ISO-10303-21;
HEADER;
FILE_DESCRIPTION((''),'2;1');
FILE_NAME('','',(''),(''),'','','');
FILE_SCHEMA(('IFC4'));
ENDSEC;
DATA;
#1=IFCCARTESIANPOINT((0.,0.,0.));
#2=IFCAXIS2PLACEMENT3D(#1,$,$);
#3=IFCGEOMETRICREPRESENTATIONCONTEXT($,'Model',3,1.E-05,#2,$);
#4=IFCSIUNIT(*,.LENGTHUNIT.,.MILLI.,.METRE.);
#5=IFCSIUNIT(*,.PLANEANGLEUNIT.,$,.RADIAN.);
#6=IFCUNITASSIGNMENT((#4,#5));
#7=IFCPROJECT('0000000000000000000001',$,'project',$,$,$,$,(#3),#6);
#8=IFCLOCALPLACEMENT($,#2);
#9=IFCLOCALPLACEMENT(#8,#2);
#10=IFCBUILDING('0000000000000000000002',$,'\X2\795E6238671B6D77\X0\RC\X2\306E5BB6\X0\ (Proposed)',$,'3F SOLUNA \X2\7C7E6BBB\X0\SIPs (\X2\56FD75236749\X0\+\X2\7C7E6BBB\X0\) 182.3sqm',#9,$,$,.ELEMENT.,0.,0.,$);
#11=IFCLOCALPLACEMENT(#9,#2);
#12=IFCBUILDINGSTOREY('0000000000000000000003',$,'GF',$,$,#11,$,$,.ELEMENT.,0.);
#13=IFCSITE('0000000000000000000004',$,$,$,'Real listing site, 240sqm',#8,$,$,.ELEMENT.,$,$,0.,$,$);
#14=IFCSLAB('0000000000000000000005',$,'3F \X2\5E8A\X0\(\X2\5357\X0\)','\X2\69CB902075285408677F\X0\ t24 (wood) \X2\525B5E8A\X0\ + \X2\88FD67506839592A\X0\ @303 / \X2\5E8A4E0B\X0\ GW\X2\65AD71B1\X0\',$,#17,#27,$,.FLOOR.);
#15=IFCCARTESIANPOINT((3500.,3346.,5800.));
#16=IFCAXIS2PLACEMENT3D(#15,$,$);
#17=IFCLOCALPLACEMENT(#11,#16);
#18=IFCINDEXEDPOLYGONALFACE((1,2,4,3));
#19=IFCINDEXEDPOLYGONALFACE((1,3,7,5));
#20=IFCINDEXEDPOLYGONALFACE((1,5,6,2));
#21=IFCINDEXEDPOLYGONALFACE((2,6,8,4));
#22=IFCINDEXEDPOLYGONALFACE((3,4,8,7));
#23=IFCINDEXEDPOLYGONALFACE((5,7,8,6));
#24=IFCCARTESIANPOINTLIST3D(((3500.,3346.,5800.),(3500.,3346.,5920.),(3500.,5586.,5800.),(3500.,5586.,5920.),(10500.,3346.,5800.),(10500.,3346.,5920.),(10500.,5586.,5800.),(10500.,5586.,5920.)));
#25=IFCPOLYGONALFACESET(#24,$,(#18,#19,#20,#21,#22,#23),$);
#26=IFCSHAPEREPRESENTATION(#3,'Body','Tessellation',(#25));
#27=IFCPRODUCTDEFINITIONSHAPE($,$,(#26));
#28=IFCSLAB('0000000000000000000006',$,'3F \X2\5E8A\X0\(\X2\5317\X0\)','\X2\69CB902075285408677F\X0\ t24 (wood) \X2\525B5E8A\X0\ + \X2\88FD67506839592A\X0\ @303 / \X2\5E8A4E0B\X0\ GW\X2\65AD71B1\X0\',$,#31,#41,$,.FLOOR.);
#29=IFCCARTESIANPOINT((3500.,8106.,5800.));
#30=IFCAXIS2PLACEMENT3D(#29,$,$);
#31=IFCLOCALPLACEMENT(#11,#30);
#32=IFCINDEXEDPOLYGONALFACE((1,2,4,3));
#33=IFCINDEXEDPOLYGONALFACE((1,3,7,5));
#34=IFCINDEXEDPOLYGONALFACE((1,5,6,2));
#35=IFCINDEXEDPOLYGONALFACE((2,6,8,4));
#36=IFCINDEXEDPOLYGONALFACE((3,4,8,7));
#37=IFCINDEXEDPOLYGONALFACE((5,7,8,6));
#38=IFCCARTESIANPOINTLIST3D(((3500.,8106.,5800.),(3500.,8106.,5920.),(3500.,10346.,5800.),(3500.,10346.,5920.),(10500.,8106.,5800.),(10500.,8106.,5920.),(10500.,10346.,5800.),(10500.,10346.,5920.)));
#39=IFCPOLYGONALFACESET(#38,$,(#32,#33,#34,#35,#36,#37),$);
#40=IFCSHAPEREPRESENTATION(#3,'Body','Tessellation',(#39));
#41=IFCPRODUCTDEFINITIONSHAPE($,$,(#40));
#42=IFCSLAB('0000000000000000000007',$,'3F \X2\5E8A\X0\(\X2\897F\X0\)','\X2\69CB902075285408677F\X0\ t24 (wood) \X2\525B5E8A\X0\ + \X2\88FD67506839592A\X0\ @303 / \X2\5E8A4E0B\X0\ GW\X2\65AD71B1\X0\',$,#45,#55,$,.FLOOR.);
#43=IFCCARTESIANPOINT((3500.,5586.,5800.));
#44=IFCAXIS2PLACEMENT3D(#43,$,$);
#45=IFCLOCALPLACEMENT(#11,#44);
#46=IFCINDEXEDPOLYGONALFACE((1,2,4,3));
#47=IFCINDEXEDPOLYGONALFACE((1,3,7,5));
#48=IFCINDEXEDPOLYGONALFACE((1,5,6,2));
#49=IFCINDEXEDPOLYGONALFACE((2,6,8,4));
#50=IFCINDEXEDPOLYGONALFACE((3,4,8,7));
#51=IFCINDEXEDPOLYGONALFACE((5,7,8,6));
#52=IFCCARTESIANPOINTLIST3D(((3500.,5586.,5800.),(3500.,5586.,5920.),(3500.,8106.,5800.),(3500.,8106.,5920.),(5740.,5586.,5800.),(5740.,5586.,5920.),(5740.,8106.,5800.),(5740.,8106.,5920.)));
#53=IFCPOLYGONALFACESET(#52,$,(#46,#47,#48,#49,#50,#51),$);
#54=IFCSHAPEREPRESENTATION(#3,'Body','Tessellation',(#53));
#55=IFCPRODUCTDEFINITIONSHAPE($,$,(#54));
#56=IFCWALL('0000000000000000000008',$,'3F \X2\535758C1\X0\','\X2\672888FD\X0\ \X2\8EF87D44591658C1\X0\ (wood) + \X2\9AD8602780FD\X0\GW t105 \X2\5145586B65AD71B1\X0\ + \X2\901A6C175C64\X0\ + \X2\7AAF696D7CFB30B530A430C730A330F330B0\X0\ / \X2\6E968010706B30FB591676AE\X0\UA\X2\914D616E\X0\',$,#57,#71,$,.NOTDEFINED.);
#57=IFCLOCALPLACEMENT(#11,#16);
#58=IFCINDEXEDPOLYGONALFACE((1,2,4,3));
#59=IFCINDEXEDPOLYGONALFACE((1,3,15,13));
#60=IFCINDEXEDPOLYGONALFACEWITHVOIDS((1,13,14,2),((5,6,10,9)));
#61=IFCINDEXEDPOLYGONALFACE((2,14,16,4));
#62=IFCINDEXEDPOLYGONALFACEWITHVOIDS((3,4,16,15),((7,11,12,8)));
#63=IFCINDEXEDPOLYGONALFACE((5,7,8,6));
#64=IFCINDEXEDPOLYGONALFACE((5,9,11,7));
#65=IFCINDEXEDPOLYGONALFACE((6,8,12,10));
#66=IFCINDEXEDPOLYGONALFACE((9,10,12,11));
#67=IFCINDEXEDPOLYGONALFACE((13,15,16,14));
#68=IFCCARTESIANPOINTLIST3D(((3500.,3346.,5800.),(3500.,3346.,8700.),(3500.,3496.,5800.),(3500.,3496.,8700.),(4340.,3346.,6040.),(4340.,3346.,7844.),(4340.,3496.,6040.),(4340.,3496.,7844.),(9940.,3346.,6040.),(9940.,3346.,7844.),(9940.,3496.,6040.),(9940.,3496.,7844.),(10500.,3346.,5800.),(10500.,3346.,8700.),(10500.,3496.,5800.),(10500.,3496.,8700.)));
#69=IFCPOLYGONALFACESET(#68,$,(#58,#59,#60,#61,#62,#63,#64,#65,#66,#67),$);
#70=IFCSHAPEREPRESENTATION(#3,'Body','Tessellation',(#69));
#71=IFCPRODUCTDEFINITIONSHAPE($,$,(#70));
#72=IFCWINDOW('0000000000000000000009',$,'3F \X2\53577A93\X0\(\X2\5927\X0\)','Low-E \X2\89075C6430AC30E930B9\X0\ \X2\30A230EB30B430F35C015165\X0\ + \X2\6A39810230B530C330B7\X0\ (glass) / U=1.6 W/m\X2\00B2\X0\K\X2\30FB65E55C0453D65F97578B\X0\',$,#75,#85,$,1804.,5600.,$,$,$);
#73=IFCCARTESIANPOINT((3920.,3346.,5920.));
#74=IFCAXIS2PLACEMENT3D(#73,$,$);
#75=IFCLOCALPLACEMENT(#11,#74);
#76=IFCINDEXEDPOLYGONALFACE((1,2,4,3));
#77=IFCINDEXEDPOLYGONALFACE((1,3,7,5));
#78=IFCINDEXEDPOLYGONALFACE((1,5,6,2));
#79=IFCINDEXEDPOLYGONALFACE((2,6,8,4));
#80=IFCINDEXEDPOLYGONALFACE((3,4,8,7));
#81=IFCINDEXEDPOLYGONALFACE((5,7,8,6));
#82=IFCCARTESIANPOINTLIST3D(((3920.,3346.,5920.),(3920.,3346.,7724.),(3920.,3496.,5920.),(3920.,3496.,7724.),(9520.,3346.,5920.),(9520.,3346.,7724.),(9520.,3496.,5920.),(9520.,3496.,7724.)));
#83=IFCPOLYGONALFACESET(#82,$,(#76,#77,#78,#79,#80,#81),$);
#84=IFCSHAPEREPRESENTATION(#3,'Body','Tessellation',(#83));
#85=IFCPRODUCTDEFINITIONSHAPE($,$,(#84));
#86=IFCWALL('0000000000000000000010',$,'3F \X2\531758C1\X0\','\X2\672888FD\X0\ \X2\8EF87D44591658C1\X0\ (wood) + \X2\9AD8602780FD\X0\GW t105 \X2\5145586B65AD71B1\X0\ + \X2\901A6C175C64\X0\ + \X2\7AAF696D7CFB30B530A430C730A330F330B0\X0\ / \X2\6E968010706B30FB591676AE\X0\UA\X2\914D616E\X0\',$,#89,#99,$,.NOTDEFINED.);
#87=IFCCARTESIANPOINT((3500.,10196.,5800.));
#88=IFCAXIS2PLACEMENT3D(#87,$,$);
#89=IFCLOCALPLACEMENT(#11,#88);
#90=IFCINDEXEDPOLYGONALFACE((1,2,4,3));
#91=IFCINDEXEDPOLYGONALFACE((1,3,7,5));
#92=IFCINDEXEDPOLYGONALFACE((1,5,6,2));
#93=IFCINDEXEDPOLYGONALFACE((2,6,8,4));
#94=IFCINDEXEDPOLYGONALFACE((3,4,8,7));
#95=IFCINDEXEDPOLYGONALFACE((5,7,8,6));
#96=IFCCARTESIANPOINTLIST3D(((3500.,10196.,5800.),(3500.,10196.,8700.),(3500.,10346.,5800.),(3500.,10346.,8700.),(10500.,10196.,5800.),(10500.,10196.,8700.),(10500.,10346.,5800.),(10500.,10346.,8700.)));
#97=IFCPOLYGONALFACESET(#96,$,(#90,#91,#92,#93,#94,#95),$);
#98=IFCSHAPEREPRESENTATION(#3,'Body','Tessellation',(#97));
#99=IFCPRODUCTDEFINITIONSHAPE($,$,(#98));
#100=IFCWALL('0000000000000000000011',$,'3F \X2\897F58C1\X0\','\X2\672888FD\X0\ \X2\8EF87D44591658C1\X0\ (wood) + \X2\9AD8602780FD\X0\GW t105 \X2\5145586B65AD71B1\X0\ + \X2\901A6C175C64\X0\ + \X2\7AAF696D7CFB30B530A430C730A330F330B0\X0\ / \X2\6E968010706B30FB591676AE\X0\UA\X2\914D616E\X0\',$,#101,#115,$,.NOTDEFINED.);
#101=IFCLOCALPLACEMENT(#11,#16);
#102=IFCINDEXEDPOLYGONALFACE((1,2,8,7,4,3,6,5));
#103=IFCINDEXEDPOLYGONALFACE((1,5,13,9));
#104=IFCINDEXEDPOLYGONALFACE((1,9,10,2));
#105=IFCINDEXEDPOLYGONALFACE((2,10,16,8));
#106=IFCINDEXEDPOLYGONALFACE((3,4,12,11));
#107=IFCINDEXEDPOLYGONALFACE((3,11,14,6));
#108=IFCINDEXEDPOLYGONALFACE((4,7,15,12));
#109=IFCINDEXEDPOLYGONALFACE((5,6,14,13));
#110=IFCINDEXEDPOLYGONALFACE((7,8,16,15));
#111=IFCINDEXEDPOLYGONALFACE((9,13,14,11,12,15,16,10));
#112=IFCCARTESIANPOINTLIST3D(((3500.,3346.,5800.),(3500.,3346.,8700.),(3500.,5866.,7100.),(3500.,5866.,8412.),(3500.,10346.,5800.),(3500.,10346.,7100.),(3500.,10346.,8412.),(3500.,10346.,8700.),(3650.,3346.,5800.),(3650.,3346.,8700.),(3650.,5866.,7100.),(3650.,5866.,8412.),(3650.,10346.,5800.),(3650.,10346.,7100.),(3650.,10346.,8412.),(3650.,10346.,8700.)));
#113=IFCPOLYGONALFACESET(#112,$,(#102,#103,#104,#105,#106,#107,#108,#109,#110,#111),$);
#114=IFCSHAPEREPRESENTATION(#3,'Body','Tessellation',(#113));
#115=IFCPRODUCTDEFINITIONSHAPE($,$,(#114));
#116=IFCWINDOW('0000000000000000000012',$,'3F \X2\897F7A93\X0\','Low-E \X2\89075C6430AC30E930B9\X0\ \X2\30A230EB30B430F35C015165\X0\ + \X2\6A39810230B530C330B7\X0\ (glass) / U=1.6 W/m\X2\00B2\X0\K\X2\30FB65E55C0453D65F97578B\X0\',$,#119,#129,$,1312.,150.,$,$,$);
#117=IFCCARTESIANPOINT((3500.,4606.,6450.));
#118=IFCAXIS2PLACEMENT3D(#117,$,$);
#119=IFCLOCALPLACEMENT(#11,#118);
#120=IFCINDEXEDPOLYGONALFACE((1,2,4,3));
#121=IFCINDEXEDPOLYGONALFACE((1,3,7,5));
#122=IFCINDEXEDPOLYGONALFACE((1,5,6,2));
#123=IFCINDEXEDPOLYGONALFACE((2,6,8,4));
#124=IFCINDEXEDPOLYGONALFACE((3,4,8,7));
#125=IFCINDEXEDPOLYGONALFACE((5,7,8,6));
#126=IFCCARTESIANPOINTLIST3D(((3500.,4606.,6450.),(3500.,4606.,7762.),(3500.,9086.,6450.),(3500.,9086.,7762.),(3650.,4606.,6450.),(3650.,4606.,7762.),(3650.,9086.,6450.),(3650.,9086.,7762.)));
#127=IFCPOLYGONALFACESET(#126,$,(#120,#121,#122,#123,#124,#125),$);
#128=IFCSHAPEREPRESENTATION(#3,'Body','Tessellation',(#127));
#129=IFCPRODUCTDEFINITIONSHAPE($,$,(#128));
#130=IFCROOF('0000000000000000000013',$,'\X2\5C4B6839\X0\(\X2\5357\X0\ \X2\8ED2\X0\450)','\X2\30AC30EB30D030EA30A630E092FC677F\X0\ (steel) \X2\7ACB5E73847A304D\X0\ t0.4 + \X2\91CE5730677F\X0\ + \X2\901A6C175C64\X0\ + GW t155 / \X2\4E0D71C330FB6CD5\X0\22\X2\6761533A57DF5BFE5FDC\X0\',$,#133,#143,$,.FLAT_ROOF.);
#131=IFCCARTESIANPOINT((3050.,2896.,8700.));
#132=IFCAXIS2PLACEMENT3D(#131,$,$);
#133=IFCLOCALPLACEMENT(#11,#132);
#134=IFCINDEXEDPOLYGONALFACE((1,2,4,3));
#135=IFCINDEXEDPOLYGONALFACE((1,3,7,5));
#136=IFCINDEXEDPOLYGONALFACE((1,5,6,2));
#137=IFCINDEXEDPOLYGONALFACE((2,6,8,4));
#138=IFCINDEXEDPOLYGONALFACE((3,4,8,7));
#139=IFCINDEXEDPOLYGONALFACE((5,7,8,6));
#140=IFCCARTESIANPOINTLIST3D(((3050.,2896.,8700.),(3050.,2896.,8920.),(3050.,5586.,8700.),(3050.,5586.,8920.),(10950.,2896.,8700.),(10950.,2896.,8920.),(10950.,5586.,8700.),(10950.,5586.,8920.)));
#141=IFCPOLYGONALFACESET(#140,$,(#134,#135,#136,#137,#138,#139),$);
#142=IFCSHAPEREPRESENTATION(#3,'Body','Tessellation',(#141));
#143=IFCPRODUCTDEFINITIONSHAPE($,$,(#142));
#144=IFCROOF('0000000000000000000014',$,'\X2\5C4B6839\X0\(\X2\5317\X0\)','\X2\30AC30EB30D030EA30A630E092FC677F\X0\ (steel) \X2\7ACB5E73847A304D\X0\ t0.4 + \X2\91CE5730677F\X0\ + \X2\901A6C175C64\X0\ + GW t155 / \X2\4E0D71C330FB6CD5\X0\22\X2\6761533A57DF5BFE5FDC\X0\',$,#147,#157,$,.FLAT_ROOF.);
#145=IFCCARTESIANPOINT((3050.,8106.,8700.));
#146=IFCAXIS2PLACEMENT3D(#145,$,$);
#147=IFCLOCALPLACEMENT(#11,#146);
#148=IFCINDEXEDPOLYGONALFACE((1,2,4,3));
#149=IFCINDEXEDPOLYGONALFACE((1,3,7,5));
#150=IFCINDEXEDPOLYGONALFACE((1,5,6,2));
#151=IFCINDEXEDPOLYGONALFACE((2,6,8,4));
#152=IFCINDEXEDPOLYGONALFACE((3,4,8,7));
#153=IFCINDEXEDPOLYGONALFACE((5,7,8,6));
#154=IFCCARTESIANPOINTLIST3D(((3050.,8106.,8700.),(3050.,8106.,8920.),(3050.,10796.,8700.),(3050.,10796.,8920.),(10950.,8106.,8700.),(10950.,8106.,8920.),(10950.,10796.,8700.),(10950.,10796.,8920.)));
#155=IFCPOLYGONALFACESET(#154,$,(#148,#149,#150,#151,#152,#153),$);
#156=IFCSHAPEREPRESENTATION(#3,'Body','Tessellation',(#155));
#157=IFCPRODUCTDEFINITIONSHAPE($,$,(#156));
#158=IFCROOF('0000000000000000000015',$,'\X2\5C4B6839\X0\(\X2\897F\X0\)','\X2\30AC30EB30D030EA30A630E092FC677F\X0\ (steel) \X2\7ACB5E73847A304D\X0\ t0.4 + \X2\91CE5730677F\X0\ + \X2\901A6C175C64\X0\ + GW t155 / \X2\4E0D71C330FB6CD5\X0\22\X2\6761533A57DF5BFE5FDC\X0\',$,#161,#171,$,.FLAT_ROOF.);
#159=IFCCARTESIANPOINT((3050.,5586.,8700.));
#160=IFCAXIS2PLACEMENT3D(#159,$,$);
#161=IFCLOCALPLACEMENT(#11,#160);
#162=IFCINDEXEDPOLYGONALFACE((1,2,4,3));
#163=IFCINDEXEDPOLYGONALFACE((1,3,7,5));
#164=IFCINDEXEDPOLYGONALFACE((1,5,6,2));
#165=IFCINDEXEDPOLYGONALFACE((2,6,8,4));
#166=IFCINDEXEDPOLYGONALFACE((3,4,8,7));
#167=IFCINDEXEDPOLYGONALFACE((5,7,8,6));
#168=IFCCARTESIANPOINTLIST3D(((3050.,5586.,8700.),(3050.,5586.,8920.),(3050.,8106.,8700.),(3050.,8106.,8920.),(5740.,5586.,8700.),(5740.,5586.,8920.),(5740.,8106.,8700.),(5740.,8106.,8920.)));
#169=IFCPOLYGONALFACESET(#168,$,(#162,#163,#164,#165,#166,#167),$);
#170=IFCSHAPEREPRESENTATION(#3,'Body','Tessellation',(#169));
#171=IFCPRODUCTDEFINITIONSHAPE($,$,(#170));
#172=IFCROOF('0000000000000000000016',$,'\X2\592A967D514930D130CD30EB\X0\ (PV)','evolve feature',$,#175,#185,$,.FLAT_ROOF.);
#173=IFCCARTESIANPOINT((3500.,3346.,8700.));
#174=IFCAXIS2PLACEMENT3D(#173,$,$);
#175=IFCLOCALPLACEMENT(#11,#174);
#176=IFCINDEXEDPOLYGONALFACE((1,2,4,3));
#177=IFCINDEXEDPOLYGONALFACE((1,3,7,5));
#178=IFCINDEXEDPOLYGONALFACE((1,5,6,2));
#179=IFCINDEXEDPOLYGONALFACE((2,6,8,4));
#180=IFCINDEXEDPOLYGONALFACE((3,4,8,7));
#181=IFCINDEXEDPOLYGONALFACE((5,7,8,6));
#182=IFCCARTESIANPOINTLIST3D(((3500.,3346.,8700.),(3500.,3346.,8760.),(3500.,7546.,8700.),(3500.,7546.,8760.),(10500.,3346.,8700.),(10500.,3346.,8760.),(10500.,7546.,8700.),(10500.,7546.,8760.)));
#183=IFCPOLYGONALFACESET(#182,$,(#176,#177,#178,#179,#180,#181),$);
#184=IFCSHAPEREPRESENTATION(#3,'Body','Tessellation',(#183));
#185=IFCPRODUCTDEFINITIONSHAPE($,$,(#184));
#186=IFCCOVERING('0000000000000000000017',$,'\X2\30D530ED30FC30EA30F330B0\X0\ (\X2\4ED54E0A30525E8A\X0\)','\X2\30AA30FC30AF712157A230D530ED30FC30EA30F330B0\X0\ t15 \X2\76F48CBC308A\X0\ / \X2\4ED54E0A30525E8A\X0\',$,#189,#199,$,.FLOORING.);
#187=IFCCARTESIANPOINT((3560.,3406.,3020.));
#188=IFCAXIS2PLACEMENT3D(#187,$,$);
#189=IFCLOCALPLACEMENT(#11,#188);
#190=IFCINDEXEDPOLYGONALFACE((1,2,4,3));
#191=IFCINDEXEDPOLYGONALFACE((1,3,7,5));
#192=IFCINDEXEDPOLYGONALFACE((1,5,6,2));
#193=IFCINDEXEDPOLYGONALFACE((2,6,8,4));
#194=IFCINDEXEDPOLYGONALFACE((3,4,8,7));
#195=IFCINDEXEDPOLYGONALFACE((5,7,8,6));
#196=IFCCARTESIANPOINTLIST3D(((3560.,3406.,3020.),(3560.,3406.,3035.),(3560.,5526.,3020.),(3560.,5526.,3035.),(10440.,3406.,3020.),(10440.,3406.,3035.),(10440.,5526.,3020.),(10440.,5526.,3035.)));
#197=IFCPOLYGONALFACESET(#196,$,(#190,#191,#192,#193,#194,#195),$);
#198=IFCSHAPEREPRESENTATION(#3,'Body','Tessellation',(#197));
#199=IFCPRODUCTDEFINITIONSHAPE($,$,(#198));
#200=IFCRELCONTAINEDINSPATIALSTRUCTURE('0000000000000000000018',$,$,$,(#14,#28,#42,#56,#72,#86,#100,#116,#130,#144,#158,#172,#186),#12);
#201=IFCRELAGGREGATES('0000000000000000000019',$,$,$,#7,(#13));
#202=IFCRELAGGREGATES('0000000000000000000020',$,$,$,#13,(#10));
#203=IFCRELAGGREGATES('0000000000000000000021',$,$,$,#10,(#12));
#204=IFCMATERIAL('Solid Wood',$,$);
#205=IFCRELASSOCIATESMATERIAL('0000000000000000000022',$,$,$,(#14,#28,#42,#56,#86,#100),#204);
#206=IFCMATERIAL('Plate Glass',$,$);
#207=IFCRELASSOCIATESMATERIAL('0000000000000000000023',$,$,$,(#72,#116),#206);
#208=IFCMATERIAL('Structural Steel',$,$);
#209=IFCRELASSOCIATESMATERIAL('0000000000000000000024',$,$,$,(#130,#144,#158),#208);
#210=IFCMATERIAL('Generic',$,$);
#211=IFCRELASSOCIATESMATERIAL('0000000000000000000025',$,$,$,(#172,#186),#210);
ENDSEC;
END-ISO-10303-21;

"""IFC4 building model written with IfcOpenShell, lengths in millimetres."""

from ifc_helpers import new_model, si_unit, frame, frame_2d, origin, place, context, project, spatial, rectangle, extrude, material, element, fill, save


model = new_model("IFC4")

# Units and contexts
model_context = context("Model", 3, precision=1e-05, world=origin())
ifc_project = project(units=[si_unit("LENGTHUNIT", "METRE", prefix="MILLI"), si_unit("PLANEANGLEUNIT", "RADIAN")], contexts=[model_context])

# Site, building, storey
site_placement = place(None, origin())
site = spatial("IfcSite", under=ifc_project, at=site_placement, ObjectType="Real listing site, 240sqm", CompositionType="ELEMENT", RefElevation=0.0)
building_placement = place(site_placement, origin())
building = spatial("IfcBuilding", under=site, at=building_placement, Name="神戸望海RCの家 (Proposed)", ObjectType="3F SOLUNA 籾殻SIPs (国産杉+籾殻) 182.3sqm", CompositionType="ELEMENT", ElevationOfRefHeight=0.0, ElevationOfTerrain=0.0)
storey_placement = place(building_placement, origin())
storey = spatial("IfcBuildingStorey", under=building, at=storey_placement, Name="GF", CompositionType="ELEMENT", Elevation=0.0)

# Slabs
ifc_material_1 = material(Name="Solid Wood")
slab_1_placement = place(storey_placement, frame((3500.0, 3346.0, 5800.0)))
element("IfcSlab", 1, at=slab_1_placement, inside=storey, material=ifc_material_1, Name="3F 床(南)", Description="構造用合板 t24 (wood) 剛床 + 製材根太 @303 / 床下 GW断熱", PredefinedType="FLOOR", context=model_context, shape_type="SweptSolid", body=[
    extrude(rectangle(XDim=7000.0, YDim=2240.0, at=frame_2d((3500.0, 1120.0))), frame((3500.0, 3346.0, 5800.0)), (0.0, 0.0, 1.0), 120.0),
])
slab_2_placement = place(storey_placement, frame((3500.0, 8106.0, 5800.0)))
element("IfcSlab", 2, at=slab_2_placement, inside=storey, material=ifc_material_1, Name="3F 床(北)", Description="構造用合板 t24 (wood) 剛床 + 製材根太 @303 / 床下 GW断熱", PredefinedType="FLOOR", context=model_context, shape_type="SweptSolid", body=[
    extrude(rectangle(XDim=7000.0, YDim=2240.0, at=frame_2d((3500.0, 1120.0))), frame((3500.0, 8106.0, 5800.0)), (0.0, 0.0, 1.0), 120.0),
])
slab_3_placement = place(storey_placement, frame((3500.0, 5586.0, 5800.0)))
element("IfcSlab", 3, at=slab_3_placement, inside=storey, material=ifc_material_1, Name="3F 床(西)", Description="構造用合板 t24 (wood) 剛床 + 製材根太 @303 / 床下 GW断熱", PredefinedType="FLOOR", context=model_context, shape_type="SweptSolid", body=[
    extrude(rectangle(XDim=2240.0, YDim=2520.0, at=frame_2d((1120.0, 1260.0))), frame((3500.0, 5586.0, 5800.0)), (0.0, 0.0, 1.0), 120.0),
])

# Wall, opening, window
wall_1_placement = place(storey_placement, frame((3500.0, 3346.0, 5800.0)))
wall_1 = element("IfcWall", 4, at=wall_1_placement, inside=storey, material=ifc_material_1, Name="3F 南壁", Description="木製 軸組外壁 (wood) + 高性能GW t105 充填断熱 + 通気層 + 窯業系サイディング / 準耐火・外皮UA配慮", PredefinedType="NOTDEFINED", context=model_context, shape_type="SweptSolid", body=[
    extrude(rectangle(XDim=7000.0, YDim=150.0, at=frame_2d((3500.0, 75.0))), frame((3500.0, 3346.0, 5800.0)), (0.0, 0.0, 1.0), 2900.0),
])
opening_1_placement = place(storey_placement, frame((3920.0, 3346.0, 5920.0)))
opening_1 = element("IfcOpeningElement", 5, at=opening_1_placement, cuts=wall_1, PredefinedType="NOTDEFINED", context=model_context, shape_type="SweptSolid", body=[
    extrude(rectangle(XDim=5600.0, YDim=150.0, at=frame_2d((2800.0, 75.0))), frame((3920.0, 3346.0, 5920.0)), (0.0, 0.0, 1.0), 1804.0),
])
ifc_material_2 = material(Name="Plate Glass")
window_1_placement = place(storey_placement, frame((3920.0, 3346.0, 5920.0)))
window_1 = element("IfcWindow", 6, at=window_1_placement, inside=storey, material=ifc_material_2, Name="3F 南窓(大)", Description="Low-E 複層ガラス アルゴン封入 + 樹脂サッシ (glass) / U=1.6 W/m²K・日射取得型", OverallHeight=1804.0, OverallWidth=5600.0, context=model_context, shape_type="SweptSolid", body=[
    extrude(rectangle(XDim=5600.0, YDim=150.0, at=frame_2d((2800.0, 75.0))), frame((3920.0, 3346.0, 5920.0)), (0.0, 0.0, 1.0), 1804.0),
])
fill(opening_1, window_1)

# Wall
wall_2_placement = place(storey_placement, frame((3500.0, 10196.0, 5800.0)))
element("IfcWall", 7, at=wall_2_placement, inside=storey, material=ifc_material_1, Name="3F 北壁", Description="木製 軸組外壁 (wood) + 高性能GW t105 充填断熱 + 通気層 + 窯業系サイディング / 準耐火・外皮UA配慮", PredefinedType="NOTDEFINED", context=model_context, shape_type="SweptSolid", body=[
    extrude(rectangle(XDim=7000.0, YDim=150.0, at=frame_2d((3500.0, 75.0))), frame((3500.0, 10196.0, 5800.0)), (0.0, 0.0, 1.0), 2900.0),
])

# Wall, opening, window
wall_3_placement = place(storey_placement, frame((3500.0, 3346.0, 5800.0)))
wall_3 = element("IfcWall", 8, at=wall_3_placement, inside=storey, material=ifc_material_1, Name="3F 西壁", Description="木製 軸組外壁 (wood) + 高性能GW t105 充填断熱 + 通気層 + 窯業系サイディング / 準耐火・外皮UA配慮", PredefinedType="NOTDEFINED", context=model_context, shape_type="SweptSolid", body=[
    extrude(rectangle(XDim=150.0, YDim=7000.0, at=frame_2d((75.0, 3500.0))), frame((3500.0, 3346.0, 5800.0)), (0.0, 0.0, 1.0), 2900.0),
])
opening_2_placement = place(storey_placement, frame((3500.0, 4606.0, 6450.0)))
opening_2 = element("IfcOpeningElement", 9, at=opening_2_placement, cuts=wall_3, PredefinedType="NOTDEFINED", context=model_context, shape_type="SweptSolid", body=[
    extrude(rectangle(XDim=150.0, YDim=4480.0, at=frame_2d((75.0, 2240.0))), frame((3500.0, 4606.0, 6450.0)), (0.0, 0.0, 1.0), 1312.0),
])
window_2_placement = place(storey_placement, frame((3500.0, 4606.0, 6450.0)))
window_2 = element("IfcWindow", 10, at=window_2_placement, inside=storey, material=ifc_material_2, Name="3F 西窓", Description="Low-E 複層ガラス アルゴン封入 + 樹脂サッシ (glass) / U=1.6 W/m²K・日射取得型", OverallHeight=1312.0, OverallWidth=150.0, context=model_context, shape_type="SweptSolid", body=[
    extrude(rectangle(XDim=150.0, YDim=4480.0, at=frame_2d((75.0, 2240.0))), frame((3500.0, 4606.0, 6450.0)), (0.0, 0.0, 1.0), 1312.0),
])
fill(opening_2, window_2)

# Roofs
ifc_material_3 = material(Name="Structural Steel")
roof_1_placement = place(storey_placement, frame((3050.0, 2896.0, 8700.0)))
element("IfcRoof", 11, at=roof_1_placement, inside=storey, material=ifc_material_3, Name="屋根(南 軒450)", Description="ガルバリウム鋼板 (steel) 立平葺き t0.4 + 野地板 + 通気層 + GW t155 / 不燃・法22条区域対応", PredefinedType="FLAT_ROOF", context=model_context, shape_type="SweptSolid", body=[
    extrude(rectangle(XDim=7900.0, YDim=2690.0, at=frame_2d((3950.0, 1345.0))), frame((3050.0, 2896.0, 8700.0)), (0.0, 0.0, 1.0), 220.0),
])
roof_2_placement = place(storey_placement, frame((3050.0, 8106.0, 8700.0)))
element("IfcRoof", 12, at=roof_2_placement, inside=storey, material=ifc_material_3, Name="屋根(北)", Description="ガルバリウム鋼板 (steel) 立平葺き t0.4 + 野地板 + 通気層 + GW t155 / 不燃・法22条区域対応", PredefinedType="FLAT_ROOF", context=model_context, shape_type="SweptSolid", body=[
    extrude(rectangle(XDim=7900.0, YDim=2690.0, at=frame_2d((3950.0, 1345.0))), frame((3050.0, 8106.0, 8700.0)), (0.0, 0.0, 1.0), 220.0),
])
roof_3_placement = place(storey_placement, frame((3050.0, 5586.0, 8700.0)))
element("IfcRoof", 13, at=roof_3_placement, inside=storey, material=ifc_material_3, Name="屋根(西)", Description="ガルバリウム鋼板 (steel) 立平葺き t0.4 + 野地板 + 通気層 + GW t155 / 不燃・法22条区域対応", PredefinedType="FLAT_ROOF", context=model_context, shape_type="SweptSolid", body=[
    extrude(rectangle(XDim=2690.0, YDim=2520.0, at=frame_2d((1345.0, 1260.0))), frame((3050.0, 5586.0, 8700.0)), (0.0, 0.0, 1.0), 220.0),
])
ifc_material_4 = material(Name="Generic")
roof_4_placement = place(storey_placement, frame((3500.0, 3346.0, 8700.0)))
element("IfcRoof", 14, at=roof_4_placement, inside=storey, material=ifc_material_4, Name="太陽光パネル (PV)", Description="evolve feature", PredefinedType="FLAT_ROOF", context=model_context, shape_type="SweptSolid", body=[
    extrude(rectangle(XDim=7000.0, YDim=4200.0, at=frame_2d((3500.0, 2100.0))), frame((3500.0, 3346.0, 8700.0)), (0.0, 0.0, 1.0), 60.0),
])

# Covering
covering_1_placement = place(storey_placement, frame((3560.0, 3406.0, 3020.0)))
element("IfcCovering", 15, at=covering_1_placement, inside=storey, material=ifc_material_4, Name="フローリング (仕上げ床)", Description="オーク無垢フローリング t15 直貼り / 仕上げ床", PredefinedType="FLOORING", context=model_context, shape_type="SweptSolid", body=[
    extrude(rectangle(XDim=6880.0, YDim=2120.0, at=frame_2d((3440.0, 1060.0))), frame((3560.0, 3406.0, 3020.0)), (0.0, 0.0, 1.0), 15.0),
])

save(model, "model.ifc")
